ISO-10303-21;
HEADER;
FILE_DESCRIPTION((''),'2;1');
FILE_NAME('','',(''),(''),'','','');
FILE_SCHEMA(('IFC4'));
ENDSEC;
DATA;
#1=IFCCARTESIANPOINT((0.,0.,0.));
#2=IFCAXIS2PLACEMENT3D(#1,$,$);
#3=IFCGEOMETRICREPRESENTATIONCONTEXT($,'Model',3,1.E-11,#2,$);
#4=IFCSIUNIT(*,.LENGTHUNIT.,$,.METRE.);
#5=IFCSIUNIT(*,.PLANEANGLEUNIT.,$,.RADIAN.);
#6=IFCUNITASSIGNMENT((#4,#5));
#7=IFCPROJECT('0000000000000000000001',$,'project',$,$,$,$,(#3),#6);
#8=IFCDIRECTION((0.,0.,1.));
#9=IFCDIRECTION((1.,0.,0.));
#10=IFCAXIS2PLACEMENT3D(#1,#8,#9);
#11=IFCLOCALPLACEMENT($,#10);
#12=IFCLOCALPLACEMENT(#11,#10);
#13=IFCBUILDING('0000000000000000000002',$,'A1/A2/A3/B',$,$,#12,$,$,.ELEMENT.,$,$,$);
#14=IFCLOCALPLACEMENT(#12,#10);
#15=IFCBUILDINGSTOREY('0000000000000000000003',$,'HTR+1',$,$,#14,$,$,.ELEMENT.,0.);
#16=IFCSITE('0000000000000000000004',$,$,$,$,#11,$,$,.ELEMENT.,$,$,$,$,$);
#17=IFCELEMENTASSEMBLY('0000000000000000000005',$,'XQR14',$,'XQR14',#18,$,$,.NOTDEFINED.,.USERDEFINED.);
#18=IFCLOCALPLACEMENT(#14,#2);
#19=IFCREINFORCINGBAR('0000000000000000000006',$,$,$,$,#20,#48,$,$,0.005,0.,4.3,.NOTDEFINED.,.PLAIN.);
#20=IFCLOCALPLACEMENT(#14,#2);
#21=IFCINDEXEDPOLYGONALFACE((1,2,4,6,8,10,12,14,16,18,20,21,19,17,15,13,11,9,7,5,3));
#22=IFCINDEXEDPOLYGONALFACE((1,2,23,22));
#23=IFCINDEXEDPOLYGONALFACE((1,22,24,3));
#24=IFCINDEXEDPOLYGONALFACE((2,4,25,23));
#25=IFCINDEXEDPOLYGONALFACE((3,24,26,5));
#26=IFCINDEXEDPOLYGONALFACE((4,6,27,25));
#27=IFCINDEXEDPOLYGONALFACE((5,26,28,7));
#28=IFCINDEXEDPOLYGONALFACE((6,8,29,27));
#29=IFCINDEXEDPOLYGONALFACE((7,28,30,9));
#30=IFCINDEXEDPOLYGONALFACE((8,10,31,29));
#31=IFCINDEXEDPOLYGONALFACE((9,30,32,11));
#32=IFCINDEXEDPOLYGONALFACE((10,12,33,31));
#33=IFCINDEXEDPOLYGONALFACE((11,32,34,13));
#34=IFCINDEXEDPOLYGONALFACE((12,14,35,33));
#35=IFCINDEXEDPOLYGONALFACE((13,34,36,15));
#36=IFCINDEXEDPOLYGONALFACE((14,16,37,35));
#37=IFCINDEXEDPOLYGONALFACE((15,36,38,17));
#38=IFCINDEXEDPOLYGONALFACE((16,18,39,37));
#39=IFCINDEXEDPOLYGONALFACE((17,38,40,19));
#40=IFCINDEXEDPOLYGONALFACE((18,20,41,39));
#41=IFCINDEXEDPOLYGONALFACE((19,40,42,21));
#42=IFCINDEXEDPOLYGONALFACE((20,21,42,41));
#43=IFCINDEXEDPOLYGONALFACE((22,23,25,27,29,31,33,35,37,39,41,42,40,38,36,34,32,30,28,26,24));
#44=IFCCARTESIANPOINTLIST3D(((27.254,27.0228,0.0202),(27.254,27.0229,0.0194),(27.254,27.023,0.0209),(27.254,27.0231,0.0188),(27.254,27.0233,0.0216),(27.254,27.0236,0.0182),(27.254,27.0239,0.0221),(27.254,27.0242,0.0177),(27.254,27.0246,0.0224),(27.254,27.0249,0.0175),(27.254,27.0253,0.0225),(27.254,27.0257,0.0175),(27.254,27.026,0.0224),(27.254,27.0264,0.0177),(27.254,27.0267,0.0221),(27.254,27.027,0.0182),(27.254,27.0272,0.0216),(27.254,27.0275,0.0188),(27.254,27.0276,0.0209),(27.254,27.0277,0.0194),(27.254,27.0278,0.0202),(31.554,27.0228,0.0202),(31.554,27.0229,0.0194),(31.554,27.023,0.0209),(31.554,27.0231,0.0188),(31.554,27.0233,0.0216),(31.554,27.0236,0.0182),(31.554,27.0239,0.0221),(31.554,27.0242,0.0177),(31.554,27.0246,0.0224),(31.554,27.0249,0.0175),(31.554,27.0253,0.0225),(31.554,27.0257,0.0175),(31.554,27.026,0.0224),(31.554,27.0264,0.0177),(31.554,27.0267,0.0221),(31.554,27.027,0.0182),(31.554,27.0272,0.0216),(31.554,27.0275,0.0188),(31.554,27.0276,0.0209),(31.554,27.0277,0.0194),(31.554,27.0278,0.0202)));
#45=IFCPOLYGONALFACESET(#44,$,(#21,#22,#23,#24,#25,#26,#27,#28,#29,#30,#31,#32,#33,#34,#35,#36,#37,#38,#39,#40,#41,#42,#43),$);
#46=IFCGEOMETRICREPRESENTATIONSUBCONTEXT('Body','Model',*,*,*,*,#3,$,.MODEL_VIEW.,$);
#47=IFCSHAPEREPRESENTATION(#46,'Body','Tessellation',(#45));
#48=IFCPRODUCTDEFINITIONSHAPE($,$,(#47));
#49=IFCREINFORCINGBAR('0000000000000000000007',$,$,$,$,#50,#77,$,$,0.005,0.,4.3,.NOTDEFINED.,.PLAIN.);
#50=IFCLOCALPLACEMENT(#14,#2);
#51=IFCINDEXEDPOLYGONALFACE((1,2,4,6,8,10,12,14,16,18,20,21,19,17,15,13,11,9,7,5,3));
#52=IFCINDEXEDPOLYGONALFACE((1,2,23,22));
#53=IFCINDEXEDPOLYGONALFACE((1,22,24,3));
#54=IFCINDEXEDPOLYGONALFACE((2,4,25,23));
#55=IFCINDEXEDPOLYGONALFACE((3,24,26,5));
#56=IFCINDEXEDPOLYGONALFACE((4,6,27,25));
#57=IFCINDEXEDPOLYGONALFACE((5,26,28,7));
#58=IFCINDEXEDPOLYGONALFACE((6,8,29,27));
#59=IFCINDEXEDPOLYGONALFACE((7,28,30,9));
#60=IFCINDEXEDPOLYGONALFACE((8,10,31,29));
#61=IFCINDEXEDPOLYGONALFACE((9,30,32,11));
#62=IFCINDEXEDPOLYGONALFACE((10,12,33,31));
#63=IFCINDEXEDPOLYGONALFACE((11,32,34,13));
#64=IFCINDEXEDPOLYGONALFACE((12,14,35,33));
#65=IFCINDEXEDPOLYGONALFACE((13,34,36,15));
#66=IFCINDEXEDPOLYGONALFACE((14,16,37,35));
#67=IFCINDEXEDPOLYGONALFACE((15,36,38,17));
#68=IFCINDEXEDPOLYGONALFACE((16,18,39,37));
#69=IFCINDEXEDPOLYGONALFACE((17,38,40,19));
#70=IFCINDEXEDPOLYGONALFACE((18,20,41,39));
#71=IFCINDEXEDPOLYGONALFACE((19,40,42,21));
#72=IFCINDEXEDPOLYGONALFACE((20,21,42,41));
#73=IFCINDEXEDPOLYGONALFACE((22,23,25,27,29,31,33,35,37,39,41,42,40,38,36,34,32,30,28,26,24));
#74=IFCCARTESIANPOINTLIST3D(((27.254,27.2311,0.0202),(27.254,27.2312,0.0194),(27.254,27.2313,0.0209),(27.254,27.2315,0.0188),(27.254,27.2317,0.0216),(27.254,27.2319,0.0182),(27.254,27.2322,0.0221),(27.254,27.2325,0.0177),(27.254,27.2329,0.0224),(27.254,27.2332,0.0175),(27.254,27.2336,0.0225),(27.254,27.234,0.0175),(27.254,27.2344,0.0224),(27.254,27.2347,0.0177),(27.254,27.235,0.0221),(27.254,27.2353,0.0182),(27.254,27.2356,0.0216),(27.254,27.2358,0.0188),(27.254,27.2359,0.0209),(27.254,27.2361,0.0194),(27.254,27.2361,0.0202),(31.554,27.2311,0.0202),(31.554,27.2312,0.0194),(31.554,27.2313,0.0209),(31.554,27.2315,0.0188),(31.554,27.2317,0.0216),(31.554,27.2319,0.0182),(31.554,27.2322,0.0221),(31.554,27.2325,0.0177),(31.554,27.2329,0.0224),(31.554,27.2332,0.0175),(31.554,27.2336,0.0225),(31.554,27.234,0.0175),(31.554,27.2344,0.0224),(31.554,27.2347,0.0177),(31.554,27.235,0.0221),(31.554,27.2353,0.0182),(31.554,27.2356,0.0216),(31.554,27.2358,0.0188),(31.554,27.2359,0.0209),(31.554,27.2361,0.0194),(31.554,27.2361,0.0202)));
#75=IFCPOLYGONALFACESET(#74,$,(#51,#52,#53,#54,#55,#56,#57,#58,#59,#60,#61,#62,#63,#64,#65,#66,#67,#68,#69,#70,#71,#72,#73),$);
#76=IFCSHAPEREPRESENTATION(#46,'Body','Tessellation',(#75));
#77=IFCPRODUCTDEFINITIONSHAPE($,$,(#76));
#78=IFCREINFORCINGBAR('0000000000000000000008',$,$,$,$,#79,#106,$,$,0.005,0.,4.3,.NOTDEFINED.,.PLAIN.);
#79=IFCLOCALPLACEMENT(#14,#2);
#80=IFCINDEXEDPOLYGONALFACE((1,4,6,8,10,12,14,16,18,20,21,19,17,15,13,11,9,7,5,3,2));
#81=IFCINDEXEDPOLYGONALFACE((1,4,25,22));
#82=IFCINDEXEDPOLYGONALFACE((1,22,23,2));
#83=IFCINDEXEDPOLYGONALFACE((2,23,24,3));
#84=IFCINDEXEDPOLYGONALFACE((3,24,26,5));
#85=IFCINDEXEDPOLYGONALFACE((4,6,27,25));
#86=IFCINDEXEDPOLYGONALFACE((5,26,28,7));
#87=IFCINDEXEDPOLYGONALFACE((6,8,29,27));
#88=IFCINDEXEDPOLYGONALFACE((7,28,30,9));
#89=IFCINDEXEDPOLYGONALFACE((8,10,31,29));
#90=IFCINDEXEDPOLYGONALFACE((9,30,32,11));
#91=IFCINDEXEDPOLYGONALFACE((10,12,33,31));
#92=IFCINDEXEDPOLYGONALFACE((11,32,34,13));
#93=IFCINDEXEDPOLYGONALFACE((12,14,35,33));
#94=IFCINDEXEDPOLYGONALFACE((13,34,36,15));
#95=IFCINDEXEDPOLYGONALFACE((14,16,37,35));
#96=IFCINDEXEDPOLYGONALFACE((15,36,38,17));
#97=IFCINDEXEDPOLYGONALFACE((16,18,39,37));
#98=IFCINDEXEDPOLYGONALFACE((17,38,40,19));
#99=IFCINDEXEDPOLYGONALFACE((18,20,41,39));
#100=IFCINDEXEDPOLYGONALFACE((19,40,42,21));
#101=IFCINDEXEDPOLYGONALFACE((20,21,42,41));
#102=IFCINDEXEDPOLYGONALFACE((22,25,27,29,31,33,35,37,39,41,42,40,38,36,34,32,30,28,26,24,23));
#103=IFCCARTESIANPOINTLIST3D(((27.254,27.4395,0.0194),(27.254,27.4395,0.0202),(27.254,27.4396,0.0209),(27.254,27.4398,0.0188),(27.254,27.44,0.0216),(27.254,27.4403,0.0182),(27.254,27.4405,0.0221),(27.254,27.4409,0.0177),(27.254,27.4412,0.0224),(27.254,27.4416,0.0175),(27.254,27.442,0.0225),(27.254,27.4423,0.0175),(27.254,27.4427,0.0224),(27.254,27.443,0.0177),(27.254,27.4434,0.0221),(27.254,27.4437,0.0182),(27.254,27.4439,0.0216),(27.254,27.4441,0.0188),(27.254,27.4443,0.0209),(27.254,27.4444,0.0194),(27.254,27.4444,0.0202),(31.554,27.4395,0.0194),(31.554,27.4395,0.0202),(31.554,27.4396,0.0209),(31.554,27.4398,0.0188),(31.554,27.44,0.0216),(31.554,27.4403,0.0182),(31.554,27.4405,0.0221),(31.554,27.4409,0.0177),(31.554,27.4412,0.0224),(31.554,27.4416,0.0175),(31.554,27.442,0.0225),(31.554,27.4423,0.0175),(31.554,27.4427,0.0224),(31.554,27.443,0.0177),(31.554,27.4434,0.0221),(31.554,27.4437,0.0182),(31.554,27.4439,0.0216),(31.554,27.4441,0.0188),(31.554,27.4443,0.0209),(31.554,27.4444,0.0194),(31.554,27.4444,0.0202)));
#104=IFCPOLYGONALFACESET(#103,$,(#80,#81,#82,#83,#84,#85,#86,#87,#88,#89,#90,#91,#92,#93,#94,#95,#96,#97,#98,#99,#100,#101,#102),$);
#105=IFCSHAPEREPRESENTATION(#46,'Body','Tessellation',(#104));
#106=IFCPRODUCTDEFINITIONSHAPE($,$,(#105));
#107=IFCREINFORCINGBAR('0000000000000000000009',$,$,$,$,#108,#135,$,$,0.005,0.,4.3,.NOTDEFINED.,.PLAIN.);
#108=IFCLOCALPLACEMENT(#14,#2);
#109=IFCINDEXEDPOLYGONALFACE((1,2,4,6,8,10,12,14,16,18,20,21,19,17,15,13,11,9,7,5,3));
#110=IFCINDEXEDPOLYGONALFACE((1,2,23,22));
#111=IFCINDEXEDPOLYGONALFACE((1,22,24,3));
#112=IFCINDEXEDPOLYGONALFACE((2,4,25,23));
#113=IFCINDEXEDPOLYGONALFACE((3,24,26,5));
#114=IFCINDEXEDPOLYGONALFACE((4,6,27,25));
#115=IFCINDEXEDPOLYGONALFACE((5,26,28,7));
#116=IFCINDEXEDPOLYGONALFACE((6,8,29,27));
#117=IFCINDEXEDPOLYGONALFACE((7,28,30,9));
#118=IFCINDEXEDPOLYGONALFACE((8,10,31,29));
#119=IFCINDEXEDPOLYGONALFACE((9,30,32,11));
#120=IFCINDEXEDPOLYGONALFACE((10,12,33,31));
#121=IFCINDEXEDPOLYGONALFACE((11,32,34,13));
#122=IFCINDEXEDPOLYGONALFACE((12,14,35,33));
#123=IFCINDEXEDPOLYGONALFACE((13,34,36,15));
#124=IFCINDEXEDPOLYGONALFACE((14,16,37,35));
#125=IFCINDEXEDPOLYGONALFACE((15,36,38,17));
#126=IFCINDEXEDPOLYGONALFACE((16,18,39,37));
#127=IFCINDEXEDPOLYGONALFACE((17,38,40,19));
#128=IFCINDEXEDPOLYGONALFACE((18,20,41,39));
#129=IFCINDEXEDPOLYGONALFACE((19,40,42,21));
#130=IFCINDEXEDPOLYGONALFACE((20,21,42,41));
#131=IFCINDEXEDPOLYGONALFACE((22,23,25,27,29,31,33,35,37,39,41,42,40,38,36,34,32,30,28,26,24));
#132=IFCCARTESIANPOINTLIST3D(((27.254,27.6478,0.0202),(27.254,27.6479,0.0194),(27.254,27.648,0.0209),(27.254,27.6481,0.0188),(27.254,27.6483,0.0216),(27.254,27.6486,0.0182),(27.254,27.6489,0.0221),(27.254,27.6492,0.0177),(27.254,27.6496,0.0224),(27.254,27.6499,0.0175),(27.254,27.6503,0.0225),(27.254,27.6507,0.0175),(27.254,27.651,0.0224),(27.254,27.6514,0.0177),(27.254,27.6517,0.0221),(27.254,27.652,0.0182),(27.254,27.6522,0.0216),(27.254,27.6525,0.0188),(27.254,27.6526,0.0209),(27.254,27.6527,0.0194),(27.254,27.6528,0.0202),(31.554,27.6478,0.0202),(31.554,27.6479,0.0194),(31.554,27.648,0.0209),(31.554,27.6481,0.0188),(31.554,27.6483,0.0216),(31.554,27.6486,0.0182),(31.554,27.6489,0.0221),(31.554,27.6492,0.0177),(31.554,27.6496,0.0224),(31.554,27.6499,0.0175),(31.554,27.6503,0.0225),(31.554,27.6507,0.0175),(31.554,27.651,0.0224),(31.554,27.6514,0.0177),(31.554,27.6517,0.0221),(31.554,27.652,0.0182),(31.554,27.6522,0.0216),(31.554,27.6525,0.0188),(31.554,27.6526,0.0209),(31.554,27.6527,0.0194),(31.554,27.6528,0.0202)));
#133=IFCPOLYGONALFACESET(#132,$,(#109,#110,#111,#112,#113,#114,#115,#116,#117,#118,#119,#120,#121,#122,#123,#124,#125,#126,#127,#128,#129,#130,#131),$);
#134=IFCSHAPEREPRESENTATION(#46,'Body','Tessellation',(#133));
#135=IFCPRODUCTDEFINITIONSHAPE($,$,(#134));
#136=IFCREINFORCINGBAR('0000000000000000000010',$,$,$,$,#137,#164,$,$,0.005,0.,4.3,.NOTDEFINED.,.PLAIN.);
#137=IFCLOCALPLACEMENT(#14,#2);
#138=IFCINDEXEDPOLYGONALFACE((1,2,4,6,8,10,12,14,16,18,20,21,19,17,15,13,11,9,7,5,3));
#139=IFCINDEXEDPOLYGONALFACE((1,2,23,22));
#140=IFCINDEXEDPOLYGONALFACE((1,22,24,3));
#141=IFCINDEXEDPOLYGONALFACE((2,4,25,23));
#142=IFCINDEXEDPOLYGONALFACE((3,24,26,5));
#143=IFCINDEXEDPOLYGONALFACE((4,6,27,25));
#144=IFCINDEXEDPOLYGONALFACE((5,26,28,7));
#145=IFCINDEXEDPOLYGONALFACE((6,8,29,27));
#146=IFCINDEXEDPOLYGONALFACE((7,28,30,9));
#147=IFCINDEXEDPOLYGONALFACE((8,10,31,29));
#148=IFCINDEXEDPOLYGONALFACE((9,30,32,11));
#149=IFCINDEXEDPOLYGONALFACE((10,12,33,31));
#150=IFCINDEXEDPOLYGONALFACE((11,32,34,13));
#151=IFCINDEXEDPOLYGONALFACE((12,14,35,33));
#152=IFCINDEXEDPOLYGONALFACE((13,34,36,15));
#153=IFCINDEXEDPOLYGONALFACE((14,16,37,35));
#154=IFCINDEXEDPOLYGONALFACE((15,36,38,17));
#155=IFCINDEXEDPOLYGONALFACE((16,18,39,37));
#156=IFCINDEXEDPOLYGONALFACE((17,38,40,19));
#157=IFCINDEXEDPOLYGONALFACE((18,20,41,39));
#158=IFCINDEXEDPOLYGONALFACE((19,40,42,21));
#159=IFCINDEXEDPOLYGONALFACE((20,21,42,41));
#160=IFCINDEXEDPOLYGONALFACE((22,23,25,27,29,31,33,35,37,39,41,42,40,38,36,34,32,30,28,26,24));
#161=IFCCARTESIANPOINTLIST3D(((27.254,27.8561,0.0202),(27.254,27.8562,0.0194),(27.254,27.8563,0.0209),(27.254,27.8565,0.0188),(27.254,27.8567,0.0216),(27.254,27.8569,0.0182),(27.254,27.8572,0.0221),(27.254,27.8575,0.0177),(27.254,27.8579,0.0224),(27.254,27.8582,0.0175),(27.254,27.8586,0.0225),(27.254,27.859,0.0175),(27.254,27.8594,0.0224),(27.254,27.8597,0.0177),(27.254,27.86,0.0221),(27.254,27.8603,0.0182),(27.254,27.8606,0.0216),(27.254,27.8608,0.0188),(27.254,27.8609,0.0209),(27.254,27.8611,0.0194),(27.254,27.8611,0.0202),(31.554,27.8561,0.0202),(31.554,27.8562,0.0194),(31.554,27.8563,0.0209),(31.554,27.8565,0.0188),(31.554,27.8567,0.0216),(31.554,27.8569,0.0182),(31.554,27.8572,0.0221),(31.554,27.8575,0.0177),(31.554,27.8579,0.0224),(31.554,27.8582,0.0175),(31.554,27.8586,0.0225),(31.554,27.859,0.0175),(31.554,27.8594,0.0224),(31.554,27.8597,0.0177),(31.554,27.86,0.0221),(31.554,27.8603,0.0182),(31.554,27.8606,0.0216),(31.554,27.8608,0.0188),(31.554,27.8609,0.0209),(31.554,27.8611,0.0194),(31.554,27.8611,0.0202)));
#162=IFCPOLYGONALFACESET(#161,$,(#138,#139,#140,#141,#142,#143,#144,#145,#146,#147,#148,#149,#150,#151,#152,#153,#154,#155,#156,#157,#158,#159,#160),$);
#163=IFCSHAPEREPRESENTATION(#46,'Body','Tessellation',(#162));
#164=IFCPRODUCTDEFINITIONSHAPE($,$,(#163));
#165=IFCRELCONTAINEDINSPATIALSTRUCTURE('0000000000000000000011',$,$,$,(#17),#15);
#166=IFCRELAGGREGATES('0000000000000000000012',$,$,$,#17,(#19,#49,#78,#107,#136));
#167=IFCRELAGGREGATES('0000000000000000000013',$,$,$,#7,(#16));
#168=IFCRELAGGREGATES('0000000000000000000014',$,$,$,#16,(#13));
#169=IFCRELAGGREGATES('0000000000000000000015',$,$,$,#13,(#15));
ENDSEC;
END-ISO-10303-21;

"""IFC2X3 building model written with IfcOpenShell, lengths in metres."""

from ifc_helpers import new_model, entity, si_unit, origin, origin_with_axes, place, context, subcontext, project, spatial, shape, element, aggregate, save


model = new_model("IFC2X3")

# Units and contexts
model_context = context("Model", 3, precision=1e-11, world=origin())
body_context = subcontext(model_context, "Body", "Model", "MODEL_VIEW")
ifc_project = project(units=[si_unit("LENGTHUNIT", "METRE"), si_unit("PLANEANGLEUNIT", "RADIAN")], contexts=[model_context])

# Site, building, storey
site_placement = place(None, origin_with_axes())
site = spatial("IfcSite", under=ifc_project, at=site_placement, CompositionType="ELEMENT")
building_placement = place(site_placement, origin_with_axes())
building = spatial("IfcBuilding", under=site, at=building_placement, Name="A1/A2/A3/B", CompositionType="ELEMENT")
storey_placement = place(building_placement, origin_with_axes())
storey = spatial("IfcBuildingStorey", under=building, at=storey_placement, Name="HTR+1", CompositionType="ELEMENT", Elevation=0.0)

# Element assembly, reinforcing bars
assembly_1_placement = place(storey_placement, origin_with_axes())
assembly_1 = element("IfcElementAssembly", 1, at=assembly_1_placement, inside=storey, Name="XQR14", ObjectType="XQR14", AssemblyPlace="NOTDEFINED", PredefinedType="USERDEFINED")
reinforcing_bar_1_placement = place(assembly_1_placement, origin_with_axes())
reinforcing_bar_1 = element("IfcReinforcingBar", 2, at=reinforcing_bar_1_placement, BarLength=4.3, BarRole="NOTDEFINED", BarSurface="PLAIN", CrossSectionArea=0.0, NominalDiameter=0.005, shapes=[
    shape(body_context, "Body", "AdvancedSweptSolid", [entity("IfcSweptDiskSolid", entity("IfcPolyline", [entity("IfcCartesianPoint", [27.254, 27.0253, 0.02]), entity("IfcCartesianPoint", [31.554, 27.0253, 0.02])]), 0.0025, None, 0.0, 4.3)]),
    shape(body_context, "Body", "AdvancedSweptSolid", [entity("IfcSweptDiskSolid", entity("IfcPolyline", [entity("IfcCartesianPoint", [27.254, 27.0253, 0.02]), entity("IfcCartesianPoint", [31.554, 27.0253, 0.02])]), 0.0025, None, 0.0, 4.3)]),
])
reinforcing_bar_2_placement = place(assembly_1_placement, origin_with_axes())
reinforcing_bar_2 = element("IfcReinforcingBar", 3, at=reinforcing_bar_2_placement, BarLength=4.3, BarRole="NOTDEFINED", BarSurface="PLAIN", CrossSectionArea=0.0, NominalDiameter=0.005, shapes=[
    shape(body_context, "Body", "AdvancedSweptSolid", [entity("IfcSweptDiskSolid", entity("IfcPolyline", [entity("IfcCartesianPoint", [27.254, 27.2336, 0.02]), entity("IfcCartesianPoint", [31.554, 27.2336, 0.02])]), 0.0025, None, 0.0, 4.3)]),
    shape(body_context, "Body", "AdvancedSweptSolid", [entity("IfcSweptDiskSolid", entity("IfcPolyline", [entity("IfcCartesianPoint", [27.254, 27.2336, 0.02]), entity("IfcCartesianPoint", [31.554, 27.2336, 0.02])]), 0.0025, None, 0.0, 4.3)]),
])
reinforcing_bar_3_placement = place(assembly_1_placement, origin_with_axes())
reinforcing_bar_3 = element("IfcReinforcingBar", 4, at=reinforcing_bar_3_placement, BarLength=4.3, BarRole="NOTDEFINED", BarSurface="PLAIN", CrossSectionArea=0.0, NominalDiameter=0.005, shapes=[
    shape(body_context, "Body", "AdvancedSweptSolid", [entity("IfcSweptDiskSolid", entity("IfcPolyline", [entity("IfcCartesianPoint", [27.254, 27.442, 0.02]), entity("IfcCartesianPoint", [31.554, 27.442, 0.02])]), 0.0025, None, 0.0, 4.3)]),
    shape(body_context, "Body", "AdvancedSweptSolid", [entity("IfcSweptDiskSolid", entity("IfcPolyline", [entity("IfcCartesianPoint", [27.254, 27.442, 0.02]), entity("IfcCartesianPoint", [31.554, 27.442, 0.02])]), 0.0025, None, 0.0, 4.3)]),
])
reinforcing_bar_4_placement = place(assembly_1_placement, origin_with_axes())
reinforcing_bar_4 = element("IfcReinforcingBar", 5, at=reinforcing_bar_4_placement, BarLength=4.3, BarRole="NOTDEFINED", BarSurface="PLAIN", CrossSectionArea=0.0, NominalDiameter=0.005, shapes=[
    shape(body_context, "Body", "AdvancedSweptSolid", [entity("IfcSweptDiskSolid", entity("IfcPolyline", [entity("IfcCartesianPoint", [27.254, 27.6503, 0.02]), entity("IfcCartesianPoint", [31.554, 27.6503, 0.02])]), 0.0025, None, 0.0, 4.3)]),
    shape(body_context, "Body", "AdvancedSweptSolid", [entity("IfcSweptDiskSolid", entity("IfcPolyline", [entity("IfcCartesianPoint", [27.254, 27.6503, 0.02]), entity("IfcCartesianPoint", [31.554, 27.6503, 0.02])]), 0.0025, None, 0.0, 4.3)]),
])
reinforcing_bar_5_placement = place(assembly_1_placement, origin_with_axes())
reinforcing_bar_5 = element("IfcReinforcingBar", 6, at=reinforcing_bar_5_placement, BarLength=4.3, BarRole="NOTDEFINED", BarSurface="PLAIN", CrossSectionArea=0.0, NominalDiameter=0.005, shapes=[
    shape(body_context, "Body", "AdvancedSweptSolid", [entity("IfcSweptDiskSolid", entity("IfcPolyline", [entity("IfcCartesianPoint", [27.254, 27.8586, 0.02]), entity("IfcCartesianPoint", [31.554, 27.8586, 0.02])]), 0.0025, None, 0.0, 4.3)]),
    shape(body_context, "Body", "AdvancedSweptSolid", [entity("IfcSweptDiskSolid", entity("IfcPolyline", [entity("IfcCartesianPoint", [27.254, 27.8586, 0.02]), entity("IfcCartesianPoint", [31.554, 27.8586, 0.02])]), 0.0025, None, 0.0, 4.3)]),
])
aggregate(assembly_1, [reinforcing_bar_1, reinforcing_bar_2, reinforcing_bar_3, reinforcing_bar_4, reinforcing_bar_5])

save(model, "model.ifc")
